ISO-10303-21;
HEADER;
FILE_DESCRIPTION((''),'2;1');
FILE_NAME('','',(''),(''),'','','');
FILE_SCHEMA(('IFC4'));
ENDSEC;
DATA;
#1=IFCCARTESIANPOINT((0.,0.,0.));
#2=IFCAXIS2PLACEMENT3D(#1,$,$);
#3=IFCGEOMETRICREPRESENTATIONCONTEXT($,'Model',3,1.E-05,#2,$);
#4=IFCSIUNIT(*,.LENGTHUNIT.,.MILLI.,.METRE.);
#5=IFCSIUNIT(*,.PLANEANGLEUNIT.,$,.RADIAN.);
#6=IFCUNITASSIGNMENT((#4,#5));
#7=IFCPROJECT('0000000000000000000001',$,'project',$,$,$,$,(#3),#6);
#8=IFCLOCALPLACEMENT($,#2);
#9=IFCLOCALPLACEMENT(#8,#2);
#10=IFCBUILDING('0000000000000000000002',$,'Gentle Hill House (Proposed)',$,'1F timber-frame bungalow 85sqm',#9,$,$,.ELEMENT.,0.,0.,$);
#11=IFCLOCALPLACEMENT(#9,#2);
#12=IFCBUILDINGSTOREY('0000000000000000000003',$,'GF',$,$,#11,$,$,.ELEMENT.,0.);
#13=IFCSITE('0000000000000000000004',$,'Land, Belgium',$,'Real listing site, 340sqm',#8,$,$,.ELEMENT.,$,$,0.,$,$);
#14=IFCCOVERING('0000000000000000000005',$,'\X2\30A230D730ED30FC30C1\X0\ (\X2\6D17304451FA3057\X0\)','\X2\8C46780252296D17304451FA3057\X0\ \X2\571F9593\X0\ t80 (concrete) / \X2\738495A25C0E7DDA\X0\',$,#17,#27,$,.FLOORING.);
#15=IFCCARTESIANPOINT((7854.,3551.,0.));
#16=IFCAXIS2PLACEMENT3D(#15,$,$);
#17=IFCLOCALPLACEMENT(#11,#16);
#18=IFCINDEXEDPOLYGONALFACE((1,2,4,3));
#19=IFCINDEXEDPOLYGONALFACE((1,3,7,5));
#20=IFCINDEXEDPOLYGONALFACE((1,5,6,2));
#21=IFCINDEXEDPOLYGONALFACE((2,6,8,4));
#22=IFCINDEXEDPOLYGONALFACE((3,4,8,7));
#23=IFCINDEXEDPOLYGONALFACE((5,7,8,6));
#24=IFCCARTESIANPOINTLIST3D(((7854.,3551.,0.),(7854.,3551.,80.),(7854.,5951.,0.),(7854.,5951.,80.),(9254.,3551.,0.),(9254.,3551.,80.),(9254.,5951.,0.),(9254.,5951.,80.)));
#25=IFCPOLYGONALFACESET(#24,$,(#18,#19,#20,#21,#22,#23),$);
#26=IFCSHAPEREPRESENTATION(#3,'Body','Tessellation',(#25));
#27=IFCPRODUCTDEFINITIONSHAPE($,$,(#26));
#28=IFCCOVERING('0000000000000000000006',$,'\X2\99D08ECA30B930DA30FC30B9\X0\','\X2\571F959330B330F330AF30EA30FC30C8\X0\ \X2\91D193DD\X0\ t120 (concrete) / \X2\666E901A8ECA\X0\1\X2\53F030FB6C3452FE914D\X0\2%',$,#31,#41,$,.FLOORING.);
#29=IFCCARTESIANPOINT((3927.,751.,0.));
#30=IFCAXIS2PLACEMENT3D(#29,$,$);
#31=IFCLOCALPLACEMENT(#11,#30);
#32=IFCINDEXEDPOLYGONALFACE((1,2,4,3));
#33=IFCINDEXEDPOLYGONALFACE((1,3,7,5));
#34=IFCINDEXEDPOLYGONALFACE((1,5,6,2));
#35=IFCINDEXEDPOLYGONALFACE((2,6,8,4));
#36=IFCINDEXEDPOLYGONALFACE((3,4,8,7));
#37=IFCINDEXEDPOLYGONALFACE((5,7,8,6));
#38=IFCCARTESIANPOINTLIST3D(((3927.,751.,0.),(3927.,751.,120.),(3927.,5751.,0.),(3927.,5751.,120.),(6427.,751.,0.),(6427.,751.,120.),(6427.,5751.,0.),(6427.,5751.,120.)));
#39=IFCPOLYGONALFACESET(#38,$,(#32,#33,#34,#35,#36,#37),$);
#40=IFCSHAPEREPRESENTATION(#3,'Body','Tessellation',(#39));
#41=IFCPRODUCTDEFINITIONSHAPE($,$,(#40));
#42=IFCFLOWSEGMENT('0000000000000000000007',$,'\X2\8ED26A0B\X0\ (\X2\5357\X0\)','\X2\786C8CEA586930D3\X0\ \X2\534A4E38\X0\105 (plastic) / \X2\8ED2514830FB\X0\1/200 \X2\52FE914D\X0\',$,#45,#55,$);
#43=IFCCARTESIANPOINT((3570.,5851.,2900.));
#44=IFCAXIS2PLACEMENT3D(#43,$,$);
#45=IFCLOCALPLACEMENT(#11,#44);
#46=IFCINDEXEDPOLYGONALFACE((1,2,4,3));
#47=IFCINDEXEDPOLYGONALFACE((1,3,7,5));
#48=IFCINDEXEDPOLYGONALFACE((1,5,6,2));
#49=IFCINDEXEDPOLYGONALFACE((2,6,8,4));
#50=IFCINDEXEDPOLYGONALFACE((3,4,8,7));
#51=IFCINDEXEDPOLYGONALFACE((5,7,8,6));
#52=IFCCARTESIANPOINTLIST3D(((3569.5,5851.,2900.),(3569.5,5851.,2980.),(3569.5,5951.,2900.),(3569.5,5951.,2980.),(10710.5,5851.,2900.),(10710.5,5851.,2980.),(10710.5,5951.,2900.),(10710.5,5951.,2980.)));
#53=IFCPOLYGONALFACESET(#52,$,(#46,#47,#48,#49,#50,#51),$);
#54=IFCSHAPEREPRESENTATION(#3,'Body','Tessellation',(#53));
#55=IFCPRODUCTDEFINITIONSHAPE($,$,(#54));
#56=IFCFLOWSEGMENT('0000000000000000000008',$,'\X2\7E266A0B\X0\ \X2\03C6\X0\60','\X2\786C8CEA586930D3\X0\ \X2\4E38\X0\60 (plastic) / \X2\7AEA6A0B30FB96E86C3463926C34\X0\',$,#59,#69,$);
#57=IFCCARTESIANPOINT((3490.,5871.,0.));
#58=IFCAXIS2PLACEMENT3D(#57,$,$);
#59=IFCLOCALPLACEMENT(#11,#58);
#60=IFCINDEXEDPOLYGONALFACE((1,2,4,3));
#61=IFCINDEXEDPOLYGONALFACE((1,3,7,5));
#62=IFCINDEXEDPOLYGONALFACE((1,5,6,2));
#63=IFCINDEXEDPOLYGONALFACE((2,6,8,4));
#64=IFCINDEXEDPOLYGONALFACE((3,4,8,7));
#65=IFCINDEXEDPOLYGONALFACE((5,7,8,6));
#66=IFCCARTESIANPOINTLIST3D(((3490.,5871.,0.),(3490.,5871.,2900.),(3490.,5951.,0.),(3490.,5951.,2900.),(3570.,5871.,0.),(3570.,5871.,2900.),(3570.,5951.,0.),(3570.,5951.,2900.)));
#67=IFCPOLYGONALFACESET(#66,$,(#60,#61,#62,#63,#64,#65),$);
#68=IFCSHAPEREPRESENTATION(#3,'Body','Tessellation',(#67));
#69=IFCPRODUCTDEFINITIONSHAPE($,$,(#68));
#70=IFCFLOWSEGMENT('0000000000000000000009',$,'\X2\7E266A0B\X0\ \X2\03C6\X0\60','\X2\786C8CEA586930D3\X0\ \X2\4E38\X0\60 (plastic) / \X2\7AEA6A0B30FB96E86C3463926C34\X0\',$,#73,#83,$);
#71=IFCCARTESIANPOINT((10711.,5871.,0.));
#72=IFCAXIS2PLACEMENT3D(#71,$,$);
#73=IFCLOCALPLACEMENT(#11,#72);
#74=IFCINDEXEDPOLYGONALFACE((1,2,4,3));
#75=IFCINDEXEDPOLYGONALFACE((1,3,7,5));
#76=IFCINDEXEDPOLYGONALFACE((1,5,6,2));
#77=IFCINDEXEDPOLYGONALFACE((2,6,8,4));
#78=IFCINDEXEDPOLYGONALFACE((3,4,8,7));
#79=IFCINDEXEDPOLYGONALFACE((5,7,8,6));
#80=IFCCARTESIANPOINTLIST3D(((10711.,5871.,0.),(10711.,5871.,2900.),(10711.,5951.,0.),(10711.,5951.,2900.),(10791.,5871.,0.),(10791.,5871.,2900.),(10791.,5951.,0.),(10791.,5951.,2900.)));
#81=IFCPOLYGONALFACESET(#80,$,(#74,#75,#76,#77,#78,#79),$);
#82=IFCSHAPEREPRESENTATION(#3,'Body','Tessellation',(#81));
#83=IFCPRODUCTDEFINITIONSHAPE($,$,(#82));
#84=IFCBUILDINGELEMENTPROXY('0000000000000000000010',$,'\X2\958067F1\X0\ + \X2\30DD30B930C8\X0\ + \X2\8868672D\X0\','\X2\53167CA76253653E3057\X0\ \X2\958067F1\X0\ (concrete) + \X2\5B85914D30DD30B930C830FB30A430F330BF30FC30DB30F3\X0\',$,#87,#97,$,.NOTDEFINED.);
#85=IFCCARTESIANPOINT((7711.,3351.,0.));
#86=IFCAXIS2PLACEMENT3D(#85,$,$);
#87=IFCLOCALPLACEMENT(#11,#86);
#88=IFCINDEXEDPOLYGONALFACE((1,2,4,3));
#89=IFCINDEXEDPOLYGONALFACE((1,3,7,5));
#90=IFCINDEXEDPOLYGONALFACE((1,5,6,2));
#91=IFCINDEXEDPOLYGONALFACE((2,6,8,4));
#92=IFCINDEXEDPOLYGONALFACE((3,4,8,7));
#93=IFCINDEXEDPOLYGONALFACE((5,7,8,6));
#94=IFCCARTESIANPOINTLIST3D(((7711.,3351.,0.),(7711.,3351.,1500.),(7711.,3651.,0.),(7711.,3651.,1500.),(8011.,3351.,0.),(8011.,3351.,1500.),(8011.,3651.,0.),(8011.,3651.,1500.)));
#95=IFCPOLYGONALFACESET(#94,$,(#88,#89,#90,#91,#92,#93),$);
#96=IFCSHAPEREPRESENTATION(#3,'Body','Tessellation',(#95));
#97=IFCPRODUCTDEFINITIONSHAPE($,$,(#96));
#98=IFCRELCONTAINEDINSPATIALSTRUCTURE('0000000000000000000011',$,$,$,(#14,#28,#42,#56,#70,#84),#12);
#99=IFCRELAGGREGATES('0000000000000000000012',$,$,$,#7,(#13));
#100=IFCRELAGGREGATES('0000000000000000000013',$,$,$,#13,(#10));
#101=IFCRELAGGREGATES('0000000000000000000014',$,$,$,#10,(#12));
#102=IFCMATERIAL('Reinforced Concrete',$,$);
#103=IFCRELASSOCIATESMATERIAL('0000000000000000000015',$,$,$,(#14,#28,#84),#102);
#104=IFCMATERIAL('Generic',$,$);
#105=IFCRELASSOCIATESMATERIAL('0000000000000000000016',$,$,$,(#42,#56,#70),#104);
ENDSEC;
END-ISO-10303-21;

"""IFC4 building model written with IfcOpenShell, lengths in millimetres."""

from ifc_helpers import new_model, si_unit, frame, frame_2d, origin, place, context, project, spatial, rectangle, extrude, material, element, save


model = new_model("IFC4")

# Units and contexts
model_context = context("Model", 3, precision=1e-05, world=origin())
ifc_project = project(units=[si_unit("LENGTHUNIT", "METRE", prefix="MILLI"), si_unit("PLANEANGLEUNIT", "RADIAN")], contexts=[model_context])

# Site, building, storey
site_placement = place(None, origin())
site = spatial("IfcSite", under=ifc_project, at=site_placement, Name="Land, Belgium", ObjectType="Real listing site, 340sqm", CompositionType="ELEMENT", RefElevation=0.0)
building_placement = place(site_placement, origin())
building = spatial("IfcBuilding", under=site, at=building_placement, Name="Gentle Hill House (Proposed)", ObjectType="1F timber-frame bungalow 85sqm", CompositionType="ELEMENT", ElevationOfRefHeight=0.0, ElevationOfTerrain=0.0)
storey_placement = place(building_placement, origin())
storey = spatial("IfcBuildingStorey", under=building, at=storey_placement, Name="GF", CompositionType="ELEMENT", Elevation=0.0)

# Shared definitions
ifc_material_1 = material(Name="Reinforced Concrete")

# Coverings
covering_1_placement = place(storey_placement, frame((7854.0, 3551.0, 0.0)))
element("IfcCovering", 1, at=covering_1_placement, inside=storey, material=ifc_material_1, Name="アプローチ (洗い出し)", Description="豆砂利洗い出し 土間 t80 (concrete) / 玄関導線", PredefinedType="FLOORING", context=model_context, shape_type="SweptSolid", body=[
    extrude(rectangle(XDim=1400.0, YDim=2400.0, at=frame_2d((700.0, 1200.0))), frame((7854.0, 3551.0, 0.0)), (0.0, 0.0, 1.0), 80.0),
])
covering_2_placement = place(storey_placement, frame((3927.0, 751.0, 0.0)))
element("IfcCovering", 2, at=covering_2_placement, inside=storey, material=ifc_material_1, Name="駐車スペース", Description="土間コンクリート 金鏝 t120 (concrete) / 普通車1台・水勾配2%", PredefinedType="FLOORING", context=model_context, shape_type="SweptSolid", body=[
    extrude(rectangle(XDim=2500.0, YDim=5000.0, at=frame_2d((1250.0, 2500.0))), frame((3927.0, 751.0, 0.0)), (0.0, 0.0, 1.0), 120.0),
])

# Flow segments
ifc_material_2 = material(Name="Generic")
flow_segment_1_placement = place(storey_placement, frame((3570.0, 5851.0, 2900.0)))
element("IfcFlowSegment", 3, at=flow_segment_1_placement, inside=storey, material=ifc_material_2, Name="軒樋 (南)", Description="硬質塩ビ 半丸105 (plastic) / 軒先・1/200 勾配", context=model_context, shape_type="SweptSolid", body=[
    extrude(rectangle(XDim=7141.0, YDim=100.0, at=frame_2d((3570.0, 50.0))), frame((3570.0, 5851.0, 2900.0)), (0.0, 0.0, 1.0), 80.0),
])
flow_segment_2_placement = place(storey_placement, frame((3490.0, 5871.0, 0.0)))
element("IfcFlowSegment", 4, at=flow_segment_2_placement, inside=storey, material=ifc_material_2, Name="縦樋 φ60", Description="硬質塩ビ 丸60 (plastic) / 竪樋・雨水排水", context=model_context, shape_type="SweptSolid", body=[
    extrude(rectangle(XDim=80.0, YDim=80.0, at=frame_2d((40.0, 40.0))), frame((3490.0, 5871.0, 0.0)), (0.0, 0.0, 1.0), 2900.0),
])
flow_segment_3_placement = place(storey_placement, frame((10711.0, 5871.0, 0.0)))
element("IfcFlowSegment", 5, at=flow_segment_3_placement, inside=storey, material=ifc_material_2, Name="縦樋 φ60", Description="硬質塩ビ 丸60 (plastic) / 竪樋・雨水排水", context=model_context, shape_type="SweptSolid", body=[
    extrude(rectangle(XDim=80.0, YDim=80.0, at=frame_2d((40.0, 40.0))), frame((10711.0, 5871.0, 0.0)), (0.0, 0.0, 1.0), 2900.0),
])

# Building element proxy
proxy_placement = place(storey_placement, frame((7711.0, 3351.0, 0.0)))
element("IfcBuildingElementProxy", 6, at=proxy_placement, inside=storey, material=ifc_material_1, Name="門柱 + ポスト + 表札", Description="化粧打放し 門柱 (concrete) + 宅配ポスト・インターホン", PredefinedType="NOTDEFINED", context=model_context, shape_type="SweptSolid", body=[
    extrude(rectangle(XDim=300.0, YDim=300.0, at=frame_2d((150.0, 150.0))), frame((7711.0, 3351.0, 0.0)), (0.0, 0.0, 1.0), 1500.0),
])

save(model, "model.ifc")
